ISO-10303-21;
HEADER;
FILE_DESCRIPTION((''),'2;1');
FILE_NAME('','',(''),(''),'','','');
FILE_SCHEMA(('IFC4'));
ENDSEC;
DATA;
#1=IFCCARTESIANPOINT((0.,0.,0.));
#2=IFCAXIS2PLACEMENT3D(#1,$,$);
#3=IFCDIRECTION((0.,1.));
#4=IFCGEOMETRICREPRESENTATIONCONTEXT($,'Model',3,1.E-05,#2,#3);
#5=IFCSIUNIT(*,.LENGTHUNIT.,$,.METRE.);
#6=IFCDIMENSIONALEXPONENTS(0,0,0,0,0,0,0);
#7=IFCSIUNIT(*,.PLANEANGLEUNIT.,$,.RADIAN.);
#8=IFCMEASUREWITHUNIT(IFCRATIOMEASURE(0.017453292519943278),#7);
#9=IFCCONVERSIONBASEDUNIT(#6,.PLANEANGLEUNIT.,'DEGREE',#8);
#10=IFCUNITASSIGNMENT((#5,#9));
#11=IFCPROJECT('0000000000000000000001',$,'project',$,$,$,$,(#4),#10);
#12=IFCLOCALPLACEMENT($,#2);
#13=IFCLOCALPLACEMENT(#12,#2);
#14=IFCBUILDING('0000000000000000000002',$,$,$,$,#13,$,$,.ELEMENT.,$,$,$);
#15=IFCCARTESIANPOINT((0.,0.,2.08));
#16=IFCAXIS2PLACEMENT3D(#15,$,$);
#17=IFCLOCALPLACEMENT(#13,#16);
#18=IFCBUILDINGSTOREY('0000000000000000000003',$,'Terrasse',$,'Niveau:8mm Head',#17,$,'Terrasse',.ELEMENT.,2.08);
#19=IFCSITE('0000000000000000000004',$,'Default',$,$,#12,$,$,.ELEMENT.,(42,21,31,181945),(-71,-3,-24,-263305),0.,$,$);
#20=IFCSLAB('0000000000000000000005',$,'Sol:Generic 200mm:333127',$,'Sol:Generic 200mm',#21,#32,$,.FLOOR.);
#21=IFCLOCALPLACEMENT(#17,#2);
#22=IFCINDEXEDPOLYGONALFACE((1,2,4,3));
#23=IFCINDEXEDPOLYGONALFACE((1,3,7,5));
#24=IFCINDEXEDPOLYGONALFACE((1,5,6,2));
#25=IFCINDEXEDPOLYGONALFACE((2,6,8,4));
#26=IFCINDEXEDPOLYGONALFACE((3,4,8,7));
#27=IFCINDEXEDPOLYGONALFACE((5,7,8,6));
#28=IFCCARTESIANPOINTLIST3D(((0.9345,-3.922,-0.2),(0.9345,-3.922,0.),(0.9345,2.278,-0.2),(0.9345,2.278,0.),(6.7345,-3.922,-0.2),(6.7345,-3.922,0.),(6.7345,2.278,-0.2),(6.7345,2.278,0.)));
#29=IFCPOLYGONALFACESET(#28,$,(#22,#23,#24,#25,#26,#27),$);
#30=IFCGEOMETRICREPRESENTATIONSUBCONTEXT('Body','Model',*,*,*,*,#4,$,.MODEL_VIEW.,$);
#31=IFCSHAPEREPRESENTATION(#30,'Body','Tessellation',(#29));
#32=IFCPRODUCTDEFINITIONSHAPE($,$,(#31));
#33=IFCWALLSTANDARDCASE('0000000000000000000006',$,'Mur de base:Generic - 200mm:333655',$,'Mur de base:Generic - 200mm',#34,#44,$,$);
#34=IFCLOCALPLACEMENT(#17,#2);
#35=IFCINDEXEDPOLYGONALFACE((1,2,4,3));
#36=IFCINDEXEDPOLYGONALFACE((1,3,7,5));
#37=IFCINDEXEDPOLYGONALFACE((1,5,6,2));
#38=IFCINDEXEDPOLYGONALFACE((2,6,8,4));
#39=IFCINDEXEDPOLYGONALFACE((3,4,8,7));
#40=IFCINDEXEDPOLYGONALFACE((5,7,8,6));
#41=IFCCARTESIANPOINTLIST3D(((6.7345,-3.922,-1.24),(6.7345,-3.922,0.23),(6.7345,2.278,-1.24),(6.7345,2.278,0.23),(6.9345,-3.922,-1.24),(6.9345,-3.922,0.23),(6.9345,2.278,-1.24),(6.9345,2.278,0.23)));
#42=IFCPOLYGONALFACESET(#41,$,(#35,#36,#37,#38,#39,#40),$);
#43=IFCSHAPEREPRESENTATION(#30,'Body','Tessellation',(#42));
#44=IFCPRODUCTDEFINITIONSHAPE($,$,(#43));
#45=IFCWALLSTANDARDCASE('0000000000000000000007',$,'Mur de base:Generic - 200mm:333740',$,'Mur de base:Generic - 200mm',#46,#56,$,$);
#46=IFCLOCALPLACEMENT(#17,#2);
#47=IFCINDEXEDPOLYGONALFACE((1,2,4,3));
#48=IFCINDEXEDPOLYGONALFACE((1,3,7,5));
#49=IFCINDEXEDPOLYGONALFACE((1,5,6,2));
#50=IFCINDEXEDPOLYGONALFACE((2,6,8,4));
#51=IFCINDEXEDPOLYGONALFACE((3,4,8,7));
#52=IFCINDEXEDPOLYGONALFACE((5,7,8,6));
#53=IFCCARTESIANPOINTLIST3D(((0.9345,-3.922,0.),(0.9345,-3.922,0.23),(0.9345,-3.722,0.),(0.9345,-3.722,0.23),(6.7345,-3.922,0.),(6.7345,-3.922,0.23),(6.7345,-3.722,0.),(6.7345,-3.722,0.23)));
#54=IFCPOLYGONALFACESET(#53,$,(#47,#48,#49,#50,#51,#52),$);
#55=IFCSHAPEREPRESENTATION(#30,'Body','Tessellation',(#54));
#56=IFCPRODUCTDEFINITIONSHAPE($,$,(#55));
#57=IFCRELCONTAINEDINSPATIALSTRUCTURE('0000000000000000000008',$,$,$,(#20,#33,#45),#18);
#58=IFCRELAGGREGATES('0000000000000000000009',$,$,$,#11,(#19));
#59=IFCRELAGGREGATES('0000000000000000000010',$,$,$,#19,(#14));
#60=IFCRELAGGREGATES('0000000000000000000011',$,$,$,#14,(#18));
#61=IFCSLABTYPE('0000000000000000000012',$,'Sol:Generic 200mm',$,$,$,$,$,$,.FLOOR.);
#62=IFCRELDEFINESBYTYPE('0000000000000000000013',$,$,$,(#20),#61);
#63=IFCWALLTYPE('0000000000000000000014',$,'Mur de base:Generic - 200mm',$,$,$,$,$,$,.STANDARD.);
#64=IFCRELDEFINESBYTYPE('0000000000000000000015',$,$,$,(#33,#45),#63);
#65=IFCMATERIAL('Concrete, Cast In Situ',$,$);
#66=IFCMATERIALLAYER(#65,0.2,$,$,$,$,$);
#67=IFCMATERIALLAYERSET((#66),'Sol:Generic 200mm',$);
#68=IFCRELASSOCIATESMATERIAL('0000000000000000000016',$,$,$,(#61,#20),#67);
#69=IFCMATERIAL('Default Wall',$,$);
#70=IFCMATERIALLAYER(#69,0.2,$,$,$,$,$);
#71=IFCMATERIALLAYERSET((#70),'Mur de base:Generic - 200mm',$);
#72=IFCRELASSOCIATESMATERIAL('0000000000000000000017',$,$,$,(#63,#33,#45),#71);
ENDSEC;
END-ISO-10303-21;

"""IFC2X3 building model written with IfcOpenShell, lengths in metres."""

from ifc_helpers import new_model, entity, si_unit, converted_unit, direction, frame, frame_2d, origin, place, context, subcontext, project, spatial, rectangle, extrude, material, layer, layer_set, layer_usage, type_object, element, save


model = new_model("IFC2X3")

# Units and contexts
model_context = context("Model", 3, precision=1e-05, world=origin(), true_north=direction((0.0, 1.0)))
body_context = subcontext(model_context, "Body", "Model", "MODEL_VIEW")
ifc_project = project(units=[si_unit("LENGTHUNIT", "METRE"), converted_unit("PLANEANGLEUNIT", "DEGREE", entity("IfcRatioMeasure", 0.017453292519943278), si_unit("PLANEANGLEUNIT", "RADIAN"), dimensions=[0, 0, 0, 0, 0, 0, 0])], contexts=[model_context])

# Site, building, storey
site_placement = place(None, origin())
site = spatial("IfcSite", under=ifc_project, at=site_placement, Name="Default", CompositionType="ELEMENT", RefLatitude=(42, 21, 31, 181945), RefLongitude=(-71, -3, -24, -263305), RefElevation=0.0)
building_placement = place(site_placement, origin())
building = spatial("IfcBuilding", under=site, at=building_placement, CompositionType="ELEMENT")
storey_placement = place(building_placement, frame((0.0, 0.0, 2.08)))
storey = spatial("IfcBuildingStorey", under=building, at=storey_placement, Name="Terrasse", ObjectType="Niveau:8mm Head", LongName="Terrasse", CompositionType="ELEMENT", Elevation=2.08)

# Slab
ifc_material_1 = material(Name="Concrete, Cast In Situ")
ifc_layer_1 = layer(ifc_material_1, 0.2)
ifc_layer_set_1 = layer_set([ifc_layer_1], Name="Sol:Generic 200mm")
ifc_layer_usage_1 = layer_usage(ifc_layer_set_1, "AXIS3", "POSITIVE", 0.0)
slab_type = type_object("IfcSlabType", Name="Sol:Generic 200mm", PredefinedType="FLOOR", material=ifc_layer_set_1)
slab_placement = place(storey_placement, origin())
element("IfcSlab", 1, at=slab_placement, inside=storey, type_object=slab_type, material=ifc_layer_usage_1, Name="Sol:Generic 200mm:333127", ObjectType="Sol:Generic 200mm", PredefinedType="FLOOR", context=body_context, shape_type="SweptSolid", body=[
    extrude(rectangle(XDim=6.2, YDim=5.8, at=frame_2d((0.0, 0.0), x_axis=(1.0, 0.0))), frame((3.8345, -0.822, 0.0), z_axis=(0.0, 0.0, -1.0), x_axis=(0.0, 1.0, 0.0)), (0.0, 0.0, 1.0), 0.2),
])

# Walls
ifc_material_2 = material(Name="Default Wall")
ifc_layer_2 = layer(ifc_material_2, 0.2)
ifc_layer_set_2 = layer_set([ifc_layer_2], Name="Mur de base:Generic - 200mm")
ifc_layer_usage_2 = layer_usage(ifc_layer_set_2, "AXIS2", "NEGATIVE", 0.1)
wall_type = type_object("IfcWallType", Name="Mur de base:Generic - 200mm", PredefinedType="STANDARD", material=ifc_layer_set_2)
wall_1_placement = place(storey_placement, frame((6.8345, 2.278, -1.24), z_axis=(0.0, 0.0, 1.0), x_axis=(0.0, -1.0, 0.0)))
element("IfcWallStandardCase", 2, at=wall_1_placement, inside=storey, type_object=wall_type, material=ifc_layer_usage_2, Name="Mur de base:Generic - 200mm:333655", ObjectType="Mur de base:Generic - 200mm", context=body_context, shape_type="SweptSolid", body=[
    extrude(rectangle(XDim=6.2, YDim=0.2, at=frame_2d((3.1, 0.0), x_axis=(-1.0, 0.0))), origin(), (0.0, 0.0, 1.0), 1.47),
])
wall_2_placement = place(storey_placement, frame((6.7345, -3.822, 0.0), z_axis=(0.0, 0.0, 1.0), x_axis=(-1.0, 0.0, 0.0)))
element("IfcWallStandardCase", 3, at=wall_2_placement, inside=storey, type_object=wall_type, material=ifc_layer_usage_2, Name="Mur de base:Generic - 200mm:333740", ObjectType="Mur de base:Generic - 200mm", context=body_context, shape_type="SweptSolid", body=[
    extrude(rectangle(XDim=5.8, YDim=0.2, at=frame_2d((2.9, 0.0), x_axis=(-1.0, 0.0))), origin(), (0.0, 0.0, 1.0), 0.23),
])

save(model, "model.ifc")
